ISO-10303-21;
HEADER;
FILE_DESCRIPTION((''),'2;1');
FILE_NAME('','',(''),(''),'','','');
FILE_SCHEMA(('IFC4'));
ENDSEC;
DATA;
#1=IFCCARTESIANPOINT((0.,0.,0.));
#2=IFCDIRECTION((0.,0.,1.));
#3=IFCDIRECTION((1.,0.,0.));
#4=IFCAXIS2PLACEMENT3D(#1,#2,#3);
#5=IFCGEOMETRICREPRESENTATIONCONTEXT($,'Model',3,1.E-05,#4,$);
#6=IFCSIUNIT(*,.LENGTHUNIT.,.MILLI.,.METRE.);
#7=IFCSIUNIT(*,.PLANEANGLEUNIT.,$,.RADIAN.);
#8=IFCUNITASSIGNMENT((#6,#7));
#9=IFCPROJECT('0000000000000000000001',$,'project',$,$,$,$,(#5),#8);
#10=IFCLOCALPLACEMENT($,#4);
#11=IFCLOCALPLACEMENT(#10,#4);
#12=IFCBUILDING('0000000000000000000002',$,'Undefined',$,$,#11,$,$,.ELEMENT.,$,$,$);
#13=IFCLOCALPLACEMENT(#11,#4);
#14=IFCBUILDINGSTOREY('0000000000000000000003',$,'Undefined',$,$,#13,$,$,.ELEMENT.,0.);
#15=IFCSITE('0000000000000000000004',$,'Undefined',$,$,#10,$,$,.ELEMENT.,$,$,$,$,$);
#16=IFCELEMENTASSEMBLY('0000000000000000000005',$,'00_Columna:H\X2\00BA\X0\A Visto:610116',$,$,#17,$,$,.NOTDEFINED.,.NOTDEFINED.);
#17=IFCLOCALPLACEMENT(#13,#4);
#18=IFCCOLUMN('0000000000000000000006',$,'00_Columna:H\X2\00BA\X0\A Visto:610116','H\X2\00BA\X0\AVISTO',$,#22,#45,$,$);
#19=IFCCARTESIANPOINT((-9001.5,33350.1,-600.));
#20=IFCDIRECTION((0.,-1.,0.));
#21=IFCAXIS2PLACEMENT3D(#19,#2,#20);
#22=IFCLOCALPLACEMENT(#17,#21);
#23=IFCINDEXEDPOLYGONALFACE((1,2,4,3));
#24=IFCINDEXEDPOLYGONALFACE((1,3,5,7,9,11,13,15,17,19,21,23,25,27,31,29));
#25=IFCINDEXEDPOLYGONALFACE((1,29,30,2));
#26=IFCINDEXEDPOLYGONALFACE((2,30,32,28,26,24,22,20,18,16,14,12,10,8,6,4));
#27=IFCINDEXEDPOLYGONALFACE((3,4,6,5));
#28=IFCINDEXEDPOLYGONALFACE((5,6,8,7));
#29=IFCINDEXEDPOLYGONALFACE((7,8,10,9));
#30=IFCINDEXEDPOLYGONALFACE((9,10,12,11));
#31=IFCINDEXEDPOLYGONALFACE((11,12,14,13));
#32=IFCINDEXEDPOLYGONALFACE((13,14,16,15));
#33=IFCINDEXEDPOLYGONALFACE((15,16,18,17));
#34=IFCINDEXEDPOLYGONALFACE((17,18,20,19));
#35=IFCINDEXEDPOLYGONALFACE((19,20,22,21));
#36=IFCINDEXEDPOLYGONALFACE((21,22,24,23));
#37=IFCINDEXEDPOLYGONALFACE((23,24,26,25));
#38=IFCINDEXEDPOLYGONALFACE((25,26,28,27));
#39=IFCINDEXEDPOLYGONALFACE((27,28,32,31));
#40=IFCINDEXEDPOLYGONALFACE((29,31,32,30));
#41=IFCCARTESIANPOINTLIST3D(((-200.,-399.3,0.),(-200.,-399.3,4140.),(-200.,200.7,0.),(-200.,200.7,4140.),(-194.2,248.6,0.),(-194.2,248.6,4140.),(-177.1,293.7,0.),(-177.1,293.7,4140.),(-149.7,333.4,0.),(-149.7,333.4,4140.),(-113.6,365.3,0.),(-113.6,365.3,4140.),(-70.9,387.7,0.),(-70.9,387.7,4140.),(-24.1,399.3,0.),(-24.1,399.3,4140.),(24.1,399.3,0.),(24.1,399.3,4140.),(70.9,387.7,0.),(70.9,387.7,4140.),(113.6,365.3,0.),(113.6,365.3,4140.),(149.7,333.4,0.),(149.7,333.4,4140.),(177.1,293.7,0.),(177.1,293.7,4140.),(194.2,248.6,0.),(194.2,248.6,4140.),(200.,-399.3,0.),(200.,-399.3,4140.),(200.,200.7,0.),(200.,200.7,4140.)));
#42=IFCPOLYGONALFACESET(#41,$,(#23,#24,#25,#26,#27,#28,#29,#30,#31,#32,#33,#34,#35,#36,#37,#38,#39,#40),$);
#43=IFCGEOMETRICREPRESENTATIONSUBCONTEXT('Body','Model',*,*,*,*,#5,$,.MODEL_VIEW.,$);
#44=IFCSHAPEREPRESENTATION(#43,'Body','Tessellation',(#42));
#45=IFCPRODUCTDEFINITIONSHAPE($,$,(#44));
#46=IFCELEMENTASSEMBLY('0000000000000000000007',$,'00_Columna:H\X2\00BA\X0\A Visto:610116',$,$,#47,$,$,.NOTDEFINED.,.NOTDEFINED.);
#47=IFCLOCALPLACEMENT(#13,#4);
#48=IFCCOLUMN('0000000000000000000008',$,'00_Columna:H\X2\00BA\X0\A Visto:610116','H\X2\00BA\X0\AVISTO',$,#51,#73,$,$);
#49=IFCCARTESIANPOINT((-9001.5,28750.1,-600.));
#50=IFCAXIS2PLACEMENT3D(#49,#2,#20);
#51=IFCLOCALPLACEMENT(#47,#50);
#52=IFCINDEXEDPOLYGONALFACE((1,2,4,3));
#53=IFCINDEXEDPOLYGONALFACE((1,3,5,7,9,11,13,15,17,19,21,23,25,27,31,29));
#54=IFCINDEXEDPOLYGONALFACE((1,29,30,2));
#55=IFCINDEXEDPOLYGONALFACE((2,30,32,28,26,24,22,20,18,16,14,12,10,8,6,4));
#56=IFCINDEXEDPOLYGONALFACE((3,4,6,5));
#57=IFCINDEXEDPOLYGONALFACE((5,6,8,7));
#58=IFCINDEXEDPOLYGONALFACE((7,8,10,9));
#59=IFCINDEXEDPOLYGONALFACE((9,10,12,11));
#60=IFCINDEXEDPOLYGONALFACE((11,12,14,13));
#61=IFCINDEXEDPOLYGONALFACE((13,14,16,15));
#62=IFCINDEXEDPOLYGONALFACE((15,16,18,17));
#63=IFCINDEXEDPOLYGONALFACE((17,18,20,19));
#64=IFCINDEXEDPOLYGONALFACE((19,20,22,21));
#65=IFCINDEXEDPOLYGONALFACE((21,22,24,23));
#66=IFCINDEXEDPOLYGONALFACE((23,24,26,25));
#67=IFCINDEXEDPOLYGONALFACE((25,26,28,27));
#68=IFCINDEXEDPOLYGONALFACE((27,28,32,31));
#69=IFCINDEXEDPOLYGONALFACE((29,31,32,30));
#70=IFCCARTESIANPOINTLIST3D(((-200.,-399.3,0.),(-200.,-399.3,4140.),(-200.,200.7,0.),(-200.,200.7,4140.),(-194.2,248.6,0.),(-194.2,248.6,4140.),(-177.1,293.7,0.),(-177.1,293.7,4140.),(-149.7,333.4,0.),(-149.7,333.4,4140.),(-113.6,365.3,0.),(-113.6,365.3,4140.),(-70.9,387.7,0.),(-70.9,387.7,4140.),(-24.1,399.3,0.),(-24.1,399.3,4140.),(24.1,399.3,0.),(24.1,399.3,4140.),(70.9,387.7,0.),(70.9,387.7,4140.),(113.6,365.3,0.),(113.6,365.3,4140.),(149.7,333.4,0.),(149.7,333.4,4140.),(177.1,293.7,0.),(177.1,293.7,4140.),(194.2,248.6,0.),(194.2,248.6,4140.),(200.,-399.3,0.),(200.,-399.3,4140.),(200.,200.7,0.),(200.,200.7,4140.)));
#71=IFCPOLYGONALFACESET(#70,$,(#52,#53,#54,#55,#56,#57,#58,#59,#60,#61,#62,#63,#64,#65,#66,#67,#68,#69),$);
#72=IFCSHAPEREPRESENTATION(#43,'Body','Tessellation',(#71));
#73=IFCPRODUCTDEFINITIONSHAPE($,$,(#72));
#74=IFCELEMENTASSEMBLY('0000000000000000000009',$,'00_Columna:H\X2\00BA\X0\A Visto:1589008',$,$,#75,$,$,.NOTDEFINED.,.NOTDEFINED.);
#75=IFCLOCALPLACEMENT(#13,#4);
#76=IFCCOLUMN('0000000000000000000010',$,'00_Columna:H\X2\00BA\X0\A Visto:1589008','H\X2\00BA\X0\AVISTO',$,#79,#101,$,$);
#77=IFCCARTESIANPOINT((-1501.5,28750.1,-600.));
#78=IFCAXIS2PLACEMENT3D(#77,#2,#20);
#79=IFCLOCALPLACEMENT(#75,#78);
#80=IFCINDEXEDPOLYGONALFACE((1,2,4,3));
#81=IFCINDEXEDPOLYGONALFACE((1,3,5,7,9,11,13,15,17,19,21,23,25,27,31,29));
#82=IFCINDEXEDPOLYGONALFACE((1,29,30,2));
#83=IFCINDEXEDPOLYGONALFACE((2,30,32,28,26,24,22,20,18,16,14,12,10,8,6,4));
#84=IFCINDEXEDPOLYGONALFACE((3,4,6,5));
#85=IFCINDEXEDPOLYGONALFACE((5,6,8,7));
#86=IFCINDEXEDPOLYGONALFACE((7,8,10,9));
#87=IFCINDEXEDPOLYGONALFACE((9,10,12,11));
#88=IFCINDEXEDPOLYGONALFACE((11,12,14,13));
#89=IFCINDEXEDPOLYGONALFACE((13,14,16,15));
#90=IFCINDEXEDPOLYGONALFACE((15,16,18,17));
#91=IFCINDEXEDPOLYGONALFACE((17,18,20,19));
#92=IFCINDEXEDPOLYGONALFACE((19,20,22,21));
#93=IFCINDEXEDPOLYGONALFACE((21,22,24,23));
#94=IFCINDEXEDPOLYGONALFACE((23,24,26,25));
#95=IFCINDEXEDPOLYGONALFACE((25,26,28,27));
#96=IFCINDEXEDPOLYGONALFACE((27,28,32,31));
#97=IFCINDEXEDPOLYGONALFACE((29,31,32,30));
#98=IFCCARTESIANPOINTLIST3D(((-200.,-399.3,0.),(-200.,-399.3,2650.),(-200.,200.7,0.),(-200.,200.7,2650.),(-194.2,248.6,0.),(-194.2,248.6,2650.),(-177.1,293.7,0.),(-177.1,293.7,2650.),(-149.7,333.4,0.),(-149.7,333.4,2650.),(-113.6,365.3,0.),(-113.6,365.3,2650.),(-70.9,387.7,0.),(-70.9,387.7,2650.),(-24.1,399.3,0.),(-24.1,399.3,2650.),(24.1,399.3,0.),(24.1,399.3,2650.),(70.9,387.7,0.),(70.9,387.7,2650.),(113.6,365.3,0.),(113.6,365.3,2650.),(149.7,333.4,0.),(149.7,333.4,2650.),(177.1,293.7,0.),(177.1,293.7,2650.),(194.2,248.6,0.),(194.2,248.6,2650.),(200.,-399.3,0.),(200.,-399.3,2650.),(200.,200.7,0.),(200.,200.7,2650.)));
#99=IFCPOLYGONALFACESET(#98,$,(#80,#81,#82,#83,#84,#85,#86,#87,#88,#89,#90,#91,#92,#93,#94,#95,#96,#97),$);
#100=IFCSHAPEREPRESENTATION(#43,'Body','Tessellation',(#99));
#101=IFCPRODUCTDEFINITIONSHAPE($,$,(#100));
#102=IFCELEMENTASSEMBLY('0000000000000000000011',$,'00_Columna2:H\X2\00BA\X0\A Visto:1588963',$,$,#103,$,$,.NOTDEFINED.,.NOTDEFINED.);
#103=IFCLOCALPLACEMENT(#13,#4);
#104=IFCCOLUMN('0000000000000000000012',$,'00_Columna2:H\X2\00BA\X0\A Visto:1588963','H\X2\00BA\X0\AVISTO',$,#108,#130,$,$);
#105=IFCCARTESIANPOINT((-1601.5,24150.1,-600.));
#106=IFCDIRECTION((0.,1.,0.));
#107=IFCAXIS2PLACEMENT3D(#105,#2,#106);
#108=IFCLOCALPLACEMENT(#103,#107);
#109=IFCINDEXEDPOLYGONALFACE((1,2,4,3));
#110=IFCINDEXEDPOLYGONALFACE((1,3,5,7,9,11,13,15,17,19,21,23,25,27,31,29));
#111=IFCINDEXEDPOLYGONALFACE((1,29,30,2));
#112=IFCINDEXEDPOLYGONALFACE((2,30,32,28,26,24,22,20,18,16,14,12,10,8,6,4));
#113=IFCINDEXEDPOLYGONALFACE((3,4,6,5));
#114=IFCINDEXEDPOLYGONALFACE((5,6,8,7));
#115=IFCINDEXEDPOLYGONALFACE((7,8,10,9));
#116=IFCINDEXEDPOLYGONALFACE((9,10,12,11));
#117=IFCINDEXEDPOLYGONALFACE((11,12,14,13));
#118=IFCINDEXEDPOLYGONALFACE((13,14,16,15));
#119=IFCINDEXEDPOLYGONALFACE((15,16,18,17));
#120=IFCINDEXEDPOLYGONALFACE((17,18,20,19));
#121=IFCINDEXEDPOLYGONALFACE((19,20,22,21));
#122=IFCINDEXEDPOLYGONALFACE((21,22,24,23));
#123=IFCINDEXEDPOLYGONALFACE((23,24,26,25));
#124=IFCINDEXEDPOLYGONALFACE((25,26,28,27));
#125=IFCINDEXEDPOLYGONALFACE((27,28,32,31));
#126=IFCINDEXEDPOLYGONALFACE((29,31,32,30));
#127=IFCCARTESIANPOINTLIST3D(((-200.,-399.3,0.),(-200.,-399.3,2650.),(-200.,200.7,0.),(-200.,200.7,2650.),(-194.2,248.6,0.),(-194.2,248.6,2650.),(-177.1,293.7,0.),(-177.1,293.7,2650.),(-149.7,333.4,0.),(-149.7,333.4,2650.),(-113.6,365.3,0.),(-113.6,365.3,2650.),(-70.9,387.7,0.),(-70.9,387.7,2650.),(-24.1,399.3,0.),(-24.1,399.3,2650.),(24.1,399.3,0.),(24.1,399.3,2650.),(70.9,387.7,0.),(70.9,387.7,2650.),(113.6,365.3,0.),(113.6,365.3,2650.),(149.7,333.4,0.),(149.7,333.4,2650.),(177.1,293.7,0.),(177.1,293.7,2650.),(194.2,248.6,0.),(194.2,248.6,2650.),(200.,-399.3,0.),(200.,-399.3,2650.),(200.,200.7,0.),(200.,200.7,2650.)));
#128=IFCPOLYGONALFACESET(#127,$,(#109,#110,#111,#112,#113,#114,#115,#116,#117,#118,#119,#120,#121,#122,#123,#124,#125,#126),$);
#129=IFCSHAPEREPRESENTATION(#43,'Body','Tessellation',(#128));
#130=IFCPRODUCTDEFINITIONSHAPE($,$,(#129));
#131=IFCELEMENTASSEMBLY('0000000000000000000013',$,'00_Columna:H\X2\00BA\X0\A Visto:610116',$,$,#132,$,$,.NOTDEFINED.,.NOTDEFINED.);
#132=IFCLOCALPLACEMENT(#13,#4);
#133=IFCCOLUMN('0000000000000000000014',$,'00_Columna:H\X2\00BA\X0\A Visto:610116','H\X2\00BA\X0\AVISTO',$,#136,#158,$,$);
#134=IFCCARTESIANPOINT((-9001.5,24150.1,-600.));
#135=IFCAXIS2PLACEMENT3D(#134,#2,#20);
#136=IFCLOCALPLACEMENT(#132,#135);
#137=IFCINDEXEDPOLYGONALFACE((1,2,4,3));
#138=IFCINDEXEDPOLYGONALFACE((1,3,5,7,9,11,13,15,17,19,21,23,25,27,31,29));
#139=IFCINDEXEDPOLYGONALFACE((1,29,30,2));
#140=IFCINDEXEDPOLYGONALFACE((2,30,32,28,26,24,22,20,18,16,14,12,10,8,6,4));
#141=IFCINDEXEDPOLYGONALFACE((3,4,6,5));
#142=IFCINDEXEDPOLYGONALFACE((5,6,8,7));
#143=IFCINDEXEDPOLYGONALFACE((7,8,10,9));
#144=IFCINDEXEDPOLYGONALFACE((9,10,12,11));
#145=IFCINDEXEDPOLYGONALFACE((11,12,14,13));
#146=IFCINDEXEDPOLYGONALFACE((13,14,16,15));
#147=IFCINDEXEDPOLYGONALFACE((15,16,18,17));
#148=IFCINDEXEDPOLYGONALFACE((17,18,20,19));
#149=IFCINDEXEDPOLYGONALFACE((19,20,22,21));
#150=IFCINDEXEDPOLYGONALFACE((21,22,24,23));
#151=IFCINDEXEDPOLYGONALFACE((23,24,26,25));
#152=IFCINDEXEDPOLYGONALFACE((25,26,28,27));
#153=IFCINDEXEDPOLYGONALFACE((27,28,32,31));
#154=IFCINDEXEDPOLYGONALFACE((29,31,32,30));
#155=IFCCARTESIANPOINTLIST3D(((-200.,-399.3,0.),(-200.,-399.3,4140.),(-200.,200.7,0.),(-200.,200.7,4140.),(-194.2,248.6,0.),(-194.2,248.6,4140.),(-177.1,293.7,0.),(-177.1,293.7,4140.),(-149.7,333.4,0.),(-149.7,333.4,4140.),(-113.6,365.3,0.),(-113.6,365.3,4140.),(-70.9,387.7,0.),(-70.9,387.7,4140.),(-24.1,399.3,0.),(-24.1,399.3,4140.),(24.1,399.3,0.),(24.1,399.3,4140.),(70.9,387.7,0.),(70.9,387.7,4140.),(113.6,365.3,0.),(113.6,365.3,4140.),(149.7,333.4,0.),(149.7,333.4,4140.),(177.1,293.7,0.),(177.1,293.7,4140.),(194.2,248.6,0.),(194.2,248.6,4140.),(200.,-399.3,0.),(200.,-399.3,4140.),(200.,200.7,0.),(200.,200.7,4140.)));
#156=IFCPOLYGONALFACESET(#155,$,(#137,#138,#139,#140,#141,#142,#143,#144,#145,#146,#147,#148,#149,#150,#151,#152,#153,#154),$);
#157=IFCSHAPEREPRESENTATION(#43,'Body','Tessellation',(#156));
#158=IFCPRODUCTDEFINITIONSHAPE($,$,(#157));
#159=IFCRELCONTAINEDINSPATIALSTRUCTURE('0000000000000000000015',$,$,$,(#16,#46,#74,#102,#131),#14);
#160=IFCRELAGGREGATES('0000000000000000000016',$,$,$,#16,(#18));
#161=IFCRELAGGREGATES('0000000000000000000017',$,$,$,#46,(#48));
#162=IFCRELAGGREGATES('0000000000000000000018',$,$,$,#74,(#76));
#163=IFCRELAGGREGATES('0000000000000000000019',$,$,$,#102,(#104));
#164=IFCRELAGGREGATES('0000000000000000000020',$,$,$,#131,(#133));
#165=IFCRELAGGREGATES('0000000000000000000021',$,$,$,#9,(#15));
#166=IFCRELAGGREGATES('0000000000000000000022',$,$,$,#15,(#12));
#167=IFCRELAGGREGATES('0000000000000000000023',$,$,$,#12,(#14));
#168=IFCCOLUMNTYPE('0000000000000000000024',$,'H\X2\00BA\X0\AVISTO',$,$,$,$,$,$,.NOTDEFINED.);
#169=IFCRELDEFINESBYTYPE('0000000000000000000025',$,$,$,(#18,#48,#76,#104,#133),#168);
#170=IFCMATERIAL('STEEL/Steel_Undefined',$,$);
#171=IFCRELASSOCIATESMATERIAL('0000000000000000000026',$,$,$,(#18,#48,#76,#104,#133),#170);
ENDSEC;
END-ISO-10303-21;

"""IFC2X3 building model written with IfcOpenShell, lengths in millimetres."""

from ifc_helpers import new_model, si_unit, frame, origin_with_axes, place, context, subcontext, project, spatial, polyline, outline, extrude, material, type_object, element, aggregate, save


model = new_model("IFC2X3")

# Units and contexts
model_context = context("Model", 3, precision=1e-05, world=origin_with_axes())
body_context = subcontext(model_context, "Body", "Model", "MODEL_VIEW")
ifc_project = project(units=[si_unit("LENGTHUNIT", "METRE", prefix="MILLI"), si_unit("PLANEANGLEUNIT", "RADIAN")], contexts=[model_context])

# Site, building, storey
site_placement = place(None, origin_with_axes())
site = spatial("IfcSite", under=ifc_project, at=site_placement, Name="Undefined", CompositionType="ELEMENT")
building_placement = place(site_placement, origin_with_axes())
building = spatial("IfcBuilding", under=site, at=building_placement, Name="Undefined", CompositionType="ELEMENT")
storey_placement = place(building_placement, origin_with_axes())
storey = spatial("IfcBuildingStorey", under=building, at=storey_placement, Name="Undefined", CompositionType="ELEMENT", Elevation=0.0)

# Element assemblies, columns
assembly_1_placement = place(storey_placement, origin_with_axes())
assembly_1 = element("IfcElementAssembly", 1, at=assembly_1_placement, inside=storey, Name="00_Columna:HºA Visto:610116", AssemblyPlace="NOTDEFINED", PredefinedType="NOTDEFINED")
ifc_material_1 = material(Name="STEEL/Steel_Undefined")
column_type_1 = type_object("IfcColumnType", Name="HºAVISTO", PredefinedType="NOTDEFINED")
column_1_placement = place(assembly_1_placement, frame((-9001.5, 33350.1, -600.0), z_axis=(0.0, 0.0, 1.0), x_axis=(0.0, -1.0, 0.0)))
column_1 = element("IfcColumn", 2, at=column_1_placement, type_object=column_type_1, material=ifc_material_1, Name="00_Columna:HºA Visto:610116", Description="HºAVISTO", context=body_context, shape_type="SweptSolid", body=[
    extrude(outline(polyline([(248.6, -194.2), (200.7, -200.0), (-399.3, -200.0), (-399.3, 200.0), (200.7, 200.0), (248.6, 194.2), (293.7, 177.1), (333.4, 149.7), (365.3, 113.6), (387.7, 70.9), (399.3, 24.1), (399.3, -24.1), (387.7, -70.9), (365.3, -113.6), (333.4, -149.7), (293.7, -177.1), (248.6, -194.2)])), frame((0.0, 0.0, 4140.0), z_axis=(0.0, 0.0, -1.0), x_axis=(0.0, 1.0, 0.0)), (0.0, 0.0, 1.0), 4140.0),
])
aggregate(assembly_1, [column_1])
assembly_2_placement = place(storey_placement, origin_with_axes())
assembly_2 = element("IfcElementAssembly", 3, at=assembly_2_placement, inside=storey, Name="00_Columna:HºA Visto:610116", AssemblyPlace="NOTDEFINED", PredefinedType="NOTDEFINED")
column_2_placement = place(assembly_2_placement, frame((-9001.5, 28750.1, -600.0), z_axis=(0.0, 0.0, 1.0), x_axis=(0.0, -1.0, 0.0)))
column_2 = element("IfcColumn", 4, at=column_2_placement, type_object=column_type_1, material=ifc_material_1, Name="00_Columna:HºA Visto:610116", Description="HºAVISTO", context=body_context, shape_type="SweptSolid", body=[
    extrude(outline(polyline([(248.6, -194.2), (200.7, -200.0), (-399.3, -200.0), (-399.3, 200.0), (200.7, 200.0), (248.6, 194.2), (293.7, 177.1), (333.4, 149.7), (365.3, 113.6), (387.7, 70.9), (399.3, 24.1), (399.3, -24.1), (387.7, -70.9), (365.3, -113.6), (333.4, -149.7), (293.7, -177.1), (248.6, -194.2)])), frame((0.0, 0.0, 4140.0), z_axis=(0.0, 0.0, -1.0), x_axis=(0.0, 1.0, 0.0)), (0.0, 0.0, 1.0), 4140.0),
])
aggregate(assembly_2, [column_2])
assembly_3_placement = place(storey_placement, origin_with_axes())
assembly_3 = element("IfcElementAssembly", 5, at=assembly_3_placement, inside=storey, Name="00_Columna:HºA Visto:1589008", AssemblyPlace="NOTDEFINED", PredefinedType="NOTDEFINED")
column_3_placement = place(assembly_3_placement, frame((-1501.5, 28750.1, -600.0), z_axis=(0.0, 0.0, 1.0), x_axis=(0.0, -1.0, 0.0)))
column_3 = element("IfcColumn", 6, at=column_3_placement, type_object=column_type_1, material=ifc_material_1, Name="00_Columna:HºA Visto:1589008", Description="HºAVISTO", context=body_context, shape_type="SweptSolid", body=[
    extrude(outline(polyline([(248.6, -194.2), (200.7, -200.0), (-399.3, -200.0), (-399.3, 200.0), (200.7, 200.0), (248.6, 194.2), (293.7, 177.1), (333.4, 149.7), (365.3, 113.6), (387.7, 70.9), (399.3, 24.1), (399.3, -24.1), (387.7, -70.9), (365.3, -113.6), (333.4, -149.7), (293.7, -177.1), (248.6, -194.2)])), frame((0.0, 0.0, 2650.0), z_axis=(0.0, 0.0, -1.0), x_axis=(0.0, 1.0, 0.0)), (0.0, 0.0, 1.0), 2650.0),
])
aggregate(assembly_3, [column_3])
assembly_4_placement = place(storey_placement, origin_with_axes())
assembly_4 = element("IfcElementAssembly", 7, at=assembly_4_placement, inside=storey, Name="00_Columna2:HºA Visto:1588963", AssemblyPlace="NOTDEFINED", PredefinedType="NOTDEFINED")
column_4_placement = place(assembly_4_placement, frame((-1601.5, 24150.1, -600.0), z_axis=(0.0, 0.0, 1.0), x_axis=(0.0, 1.0, 0.0)))
column_4 = element("IfcColumn", 8, at=column_4_placement, type_object=column_type_1, material=ifc_material_1, Name="00_Columna2:HºA Visto:1588963", Description="HºAVISTO", context=body_context, shape_type="SweptSolid", body=[
    extrude(outline(polyline([(248.6, -194.2), (200.7, -200.0), (-399.3, -200.0), (-399.3, 200.0), (200.7, 200.0), (248.6, 194.2), (293.7, 177.1), (333.4, 149.7), (365.3, 113.6), (387.7, 70.9), (399.3, 24.1), (399.3, -24.1), (387.7, -70.9), (365.3, -113.6), (333.4, -149.7), (293.7, -177.1), (248.6, -194.2)])), frame((0.0, 0.0, 2650.0), z_axis=(0.0, 0.0, -1.0), x_axis=(0.0, 1.0, 0.0)), (0.0, 0.0, 1.0), 2650.0),
])
aggregate(assembly_4, [column_4])
assembly_5_placement = place(storey_placement, origin_with_axes())
assembly_5 = element("IfcElementAssembly", 9, at=assembly_5_placement, inside=storey, Name="00_Columna:HºA Visto:610116", AssemblyPlace="NOTDEFINED", PredefinedType="NOTDEFINED")
column_5_placement = place(assembly_5_placement, frame((-9001.5, 24150.1, -600.0), z_axis=(0.0, 0.0, 1.0), x_axis=(0.0, -1.0, 0.0)))
column_5 = element("IfcColumn", 10, at=column_5_placement, type_object=column_type_1, material=ifc_material_1, Name="00_Columna:HºA Visto:610116", Description="HºAVISTO", context=body_context, shape_type="SweptSolid", body=[
    extrude(outline(polyline([(248.6, -194.2), (200.7, -200.0), (-399.3, -200.0), (-399.3, 200.0), (200.7, 200.0), (248.6, 194.2), (293.7, 177.1), (333.4, 149.7), (365.3, 113.6), (387.7, 70.9), (399.3, 24.1), (399.3, -24.1), (387.7, -70.9), (365.3, -113.6), (333.4, -149.7), (293.7, -177.1), (248.6, -194.2)])), frame((0.0, 0.0, 4140.0), z_axis=(0.0, 0.0, -1.0), x_axis=(0.0, 1.0, 0.0)), (0.0, 0.0, 1.0), 4140.0),
])
aggregate(assembly_5, [column_5])

save(model, "model.ifc")
